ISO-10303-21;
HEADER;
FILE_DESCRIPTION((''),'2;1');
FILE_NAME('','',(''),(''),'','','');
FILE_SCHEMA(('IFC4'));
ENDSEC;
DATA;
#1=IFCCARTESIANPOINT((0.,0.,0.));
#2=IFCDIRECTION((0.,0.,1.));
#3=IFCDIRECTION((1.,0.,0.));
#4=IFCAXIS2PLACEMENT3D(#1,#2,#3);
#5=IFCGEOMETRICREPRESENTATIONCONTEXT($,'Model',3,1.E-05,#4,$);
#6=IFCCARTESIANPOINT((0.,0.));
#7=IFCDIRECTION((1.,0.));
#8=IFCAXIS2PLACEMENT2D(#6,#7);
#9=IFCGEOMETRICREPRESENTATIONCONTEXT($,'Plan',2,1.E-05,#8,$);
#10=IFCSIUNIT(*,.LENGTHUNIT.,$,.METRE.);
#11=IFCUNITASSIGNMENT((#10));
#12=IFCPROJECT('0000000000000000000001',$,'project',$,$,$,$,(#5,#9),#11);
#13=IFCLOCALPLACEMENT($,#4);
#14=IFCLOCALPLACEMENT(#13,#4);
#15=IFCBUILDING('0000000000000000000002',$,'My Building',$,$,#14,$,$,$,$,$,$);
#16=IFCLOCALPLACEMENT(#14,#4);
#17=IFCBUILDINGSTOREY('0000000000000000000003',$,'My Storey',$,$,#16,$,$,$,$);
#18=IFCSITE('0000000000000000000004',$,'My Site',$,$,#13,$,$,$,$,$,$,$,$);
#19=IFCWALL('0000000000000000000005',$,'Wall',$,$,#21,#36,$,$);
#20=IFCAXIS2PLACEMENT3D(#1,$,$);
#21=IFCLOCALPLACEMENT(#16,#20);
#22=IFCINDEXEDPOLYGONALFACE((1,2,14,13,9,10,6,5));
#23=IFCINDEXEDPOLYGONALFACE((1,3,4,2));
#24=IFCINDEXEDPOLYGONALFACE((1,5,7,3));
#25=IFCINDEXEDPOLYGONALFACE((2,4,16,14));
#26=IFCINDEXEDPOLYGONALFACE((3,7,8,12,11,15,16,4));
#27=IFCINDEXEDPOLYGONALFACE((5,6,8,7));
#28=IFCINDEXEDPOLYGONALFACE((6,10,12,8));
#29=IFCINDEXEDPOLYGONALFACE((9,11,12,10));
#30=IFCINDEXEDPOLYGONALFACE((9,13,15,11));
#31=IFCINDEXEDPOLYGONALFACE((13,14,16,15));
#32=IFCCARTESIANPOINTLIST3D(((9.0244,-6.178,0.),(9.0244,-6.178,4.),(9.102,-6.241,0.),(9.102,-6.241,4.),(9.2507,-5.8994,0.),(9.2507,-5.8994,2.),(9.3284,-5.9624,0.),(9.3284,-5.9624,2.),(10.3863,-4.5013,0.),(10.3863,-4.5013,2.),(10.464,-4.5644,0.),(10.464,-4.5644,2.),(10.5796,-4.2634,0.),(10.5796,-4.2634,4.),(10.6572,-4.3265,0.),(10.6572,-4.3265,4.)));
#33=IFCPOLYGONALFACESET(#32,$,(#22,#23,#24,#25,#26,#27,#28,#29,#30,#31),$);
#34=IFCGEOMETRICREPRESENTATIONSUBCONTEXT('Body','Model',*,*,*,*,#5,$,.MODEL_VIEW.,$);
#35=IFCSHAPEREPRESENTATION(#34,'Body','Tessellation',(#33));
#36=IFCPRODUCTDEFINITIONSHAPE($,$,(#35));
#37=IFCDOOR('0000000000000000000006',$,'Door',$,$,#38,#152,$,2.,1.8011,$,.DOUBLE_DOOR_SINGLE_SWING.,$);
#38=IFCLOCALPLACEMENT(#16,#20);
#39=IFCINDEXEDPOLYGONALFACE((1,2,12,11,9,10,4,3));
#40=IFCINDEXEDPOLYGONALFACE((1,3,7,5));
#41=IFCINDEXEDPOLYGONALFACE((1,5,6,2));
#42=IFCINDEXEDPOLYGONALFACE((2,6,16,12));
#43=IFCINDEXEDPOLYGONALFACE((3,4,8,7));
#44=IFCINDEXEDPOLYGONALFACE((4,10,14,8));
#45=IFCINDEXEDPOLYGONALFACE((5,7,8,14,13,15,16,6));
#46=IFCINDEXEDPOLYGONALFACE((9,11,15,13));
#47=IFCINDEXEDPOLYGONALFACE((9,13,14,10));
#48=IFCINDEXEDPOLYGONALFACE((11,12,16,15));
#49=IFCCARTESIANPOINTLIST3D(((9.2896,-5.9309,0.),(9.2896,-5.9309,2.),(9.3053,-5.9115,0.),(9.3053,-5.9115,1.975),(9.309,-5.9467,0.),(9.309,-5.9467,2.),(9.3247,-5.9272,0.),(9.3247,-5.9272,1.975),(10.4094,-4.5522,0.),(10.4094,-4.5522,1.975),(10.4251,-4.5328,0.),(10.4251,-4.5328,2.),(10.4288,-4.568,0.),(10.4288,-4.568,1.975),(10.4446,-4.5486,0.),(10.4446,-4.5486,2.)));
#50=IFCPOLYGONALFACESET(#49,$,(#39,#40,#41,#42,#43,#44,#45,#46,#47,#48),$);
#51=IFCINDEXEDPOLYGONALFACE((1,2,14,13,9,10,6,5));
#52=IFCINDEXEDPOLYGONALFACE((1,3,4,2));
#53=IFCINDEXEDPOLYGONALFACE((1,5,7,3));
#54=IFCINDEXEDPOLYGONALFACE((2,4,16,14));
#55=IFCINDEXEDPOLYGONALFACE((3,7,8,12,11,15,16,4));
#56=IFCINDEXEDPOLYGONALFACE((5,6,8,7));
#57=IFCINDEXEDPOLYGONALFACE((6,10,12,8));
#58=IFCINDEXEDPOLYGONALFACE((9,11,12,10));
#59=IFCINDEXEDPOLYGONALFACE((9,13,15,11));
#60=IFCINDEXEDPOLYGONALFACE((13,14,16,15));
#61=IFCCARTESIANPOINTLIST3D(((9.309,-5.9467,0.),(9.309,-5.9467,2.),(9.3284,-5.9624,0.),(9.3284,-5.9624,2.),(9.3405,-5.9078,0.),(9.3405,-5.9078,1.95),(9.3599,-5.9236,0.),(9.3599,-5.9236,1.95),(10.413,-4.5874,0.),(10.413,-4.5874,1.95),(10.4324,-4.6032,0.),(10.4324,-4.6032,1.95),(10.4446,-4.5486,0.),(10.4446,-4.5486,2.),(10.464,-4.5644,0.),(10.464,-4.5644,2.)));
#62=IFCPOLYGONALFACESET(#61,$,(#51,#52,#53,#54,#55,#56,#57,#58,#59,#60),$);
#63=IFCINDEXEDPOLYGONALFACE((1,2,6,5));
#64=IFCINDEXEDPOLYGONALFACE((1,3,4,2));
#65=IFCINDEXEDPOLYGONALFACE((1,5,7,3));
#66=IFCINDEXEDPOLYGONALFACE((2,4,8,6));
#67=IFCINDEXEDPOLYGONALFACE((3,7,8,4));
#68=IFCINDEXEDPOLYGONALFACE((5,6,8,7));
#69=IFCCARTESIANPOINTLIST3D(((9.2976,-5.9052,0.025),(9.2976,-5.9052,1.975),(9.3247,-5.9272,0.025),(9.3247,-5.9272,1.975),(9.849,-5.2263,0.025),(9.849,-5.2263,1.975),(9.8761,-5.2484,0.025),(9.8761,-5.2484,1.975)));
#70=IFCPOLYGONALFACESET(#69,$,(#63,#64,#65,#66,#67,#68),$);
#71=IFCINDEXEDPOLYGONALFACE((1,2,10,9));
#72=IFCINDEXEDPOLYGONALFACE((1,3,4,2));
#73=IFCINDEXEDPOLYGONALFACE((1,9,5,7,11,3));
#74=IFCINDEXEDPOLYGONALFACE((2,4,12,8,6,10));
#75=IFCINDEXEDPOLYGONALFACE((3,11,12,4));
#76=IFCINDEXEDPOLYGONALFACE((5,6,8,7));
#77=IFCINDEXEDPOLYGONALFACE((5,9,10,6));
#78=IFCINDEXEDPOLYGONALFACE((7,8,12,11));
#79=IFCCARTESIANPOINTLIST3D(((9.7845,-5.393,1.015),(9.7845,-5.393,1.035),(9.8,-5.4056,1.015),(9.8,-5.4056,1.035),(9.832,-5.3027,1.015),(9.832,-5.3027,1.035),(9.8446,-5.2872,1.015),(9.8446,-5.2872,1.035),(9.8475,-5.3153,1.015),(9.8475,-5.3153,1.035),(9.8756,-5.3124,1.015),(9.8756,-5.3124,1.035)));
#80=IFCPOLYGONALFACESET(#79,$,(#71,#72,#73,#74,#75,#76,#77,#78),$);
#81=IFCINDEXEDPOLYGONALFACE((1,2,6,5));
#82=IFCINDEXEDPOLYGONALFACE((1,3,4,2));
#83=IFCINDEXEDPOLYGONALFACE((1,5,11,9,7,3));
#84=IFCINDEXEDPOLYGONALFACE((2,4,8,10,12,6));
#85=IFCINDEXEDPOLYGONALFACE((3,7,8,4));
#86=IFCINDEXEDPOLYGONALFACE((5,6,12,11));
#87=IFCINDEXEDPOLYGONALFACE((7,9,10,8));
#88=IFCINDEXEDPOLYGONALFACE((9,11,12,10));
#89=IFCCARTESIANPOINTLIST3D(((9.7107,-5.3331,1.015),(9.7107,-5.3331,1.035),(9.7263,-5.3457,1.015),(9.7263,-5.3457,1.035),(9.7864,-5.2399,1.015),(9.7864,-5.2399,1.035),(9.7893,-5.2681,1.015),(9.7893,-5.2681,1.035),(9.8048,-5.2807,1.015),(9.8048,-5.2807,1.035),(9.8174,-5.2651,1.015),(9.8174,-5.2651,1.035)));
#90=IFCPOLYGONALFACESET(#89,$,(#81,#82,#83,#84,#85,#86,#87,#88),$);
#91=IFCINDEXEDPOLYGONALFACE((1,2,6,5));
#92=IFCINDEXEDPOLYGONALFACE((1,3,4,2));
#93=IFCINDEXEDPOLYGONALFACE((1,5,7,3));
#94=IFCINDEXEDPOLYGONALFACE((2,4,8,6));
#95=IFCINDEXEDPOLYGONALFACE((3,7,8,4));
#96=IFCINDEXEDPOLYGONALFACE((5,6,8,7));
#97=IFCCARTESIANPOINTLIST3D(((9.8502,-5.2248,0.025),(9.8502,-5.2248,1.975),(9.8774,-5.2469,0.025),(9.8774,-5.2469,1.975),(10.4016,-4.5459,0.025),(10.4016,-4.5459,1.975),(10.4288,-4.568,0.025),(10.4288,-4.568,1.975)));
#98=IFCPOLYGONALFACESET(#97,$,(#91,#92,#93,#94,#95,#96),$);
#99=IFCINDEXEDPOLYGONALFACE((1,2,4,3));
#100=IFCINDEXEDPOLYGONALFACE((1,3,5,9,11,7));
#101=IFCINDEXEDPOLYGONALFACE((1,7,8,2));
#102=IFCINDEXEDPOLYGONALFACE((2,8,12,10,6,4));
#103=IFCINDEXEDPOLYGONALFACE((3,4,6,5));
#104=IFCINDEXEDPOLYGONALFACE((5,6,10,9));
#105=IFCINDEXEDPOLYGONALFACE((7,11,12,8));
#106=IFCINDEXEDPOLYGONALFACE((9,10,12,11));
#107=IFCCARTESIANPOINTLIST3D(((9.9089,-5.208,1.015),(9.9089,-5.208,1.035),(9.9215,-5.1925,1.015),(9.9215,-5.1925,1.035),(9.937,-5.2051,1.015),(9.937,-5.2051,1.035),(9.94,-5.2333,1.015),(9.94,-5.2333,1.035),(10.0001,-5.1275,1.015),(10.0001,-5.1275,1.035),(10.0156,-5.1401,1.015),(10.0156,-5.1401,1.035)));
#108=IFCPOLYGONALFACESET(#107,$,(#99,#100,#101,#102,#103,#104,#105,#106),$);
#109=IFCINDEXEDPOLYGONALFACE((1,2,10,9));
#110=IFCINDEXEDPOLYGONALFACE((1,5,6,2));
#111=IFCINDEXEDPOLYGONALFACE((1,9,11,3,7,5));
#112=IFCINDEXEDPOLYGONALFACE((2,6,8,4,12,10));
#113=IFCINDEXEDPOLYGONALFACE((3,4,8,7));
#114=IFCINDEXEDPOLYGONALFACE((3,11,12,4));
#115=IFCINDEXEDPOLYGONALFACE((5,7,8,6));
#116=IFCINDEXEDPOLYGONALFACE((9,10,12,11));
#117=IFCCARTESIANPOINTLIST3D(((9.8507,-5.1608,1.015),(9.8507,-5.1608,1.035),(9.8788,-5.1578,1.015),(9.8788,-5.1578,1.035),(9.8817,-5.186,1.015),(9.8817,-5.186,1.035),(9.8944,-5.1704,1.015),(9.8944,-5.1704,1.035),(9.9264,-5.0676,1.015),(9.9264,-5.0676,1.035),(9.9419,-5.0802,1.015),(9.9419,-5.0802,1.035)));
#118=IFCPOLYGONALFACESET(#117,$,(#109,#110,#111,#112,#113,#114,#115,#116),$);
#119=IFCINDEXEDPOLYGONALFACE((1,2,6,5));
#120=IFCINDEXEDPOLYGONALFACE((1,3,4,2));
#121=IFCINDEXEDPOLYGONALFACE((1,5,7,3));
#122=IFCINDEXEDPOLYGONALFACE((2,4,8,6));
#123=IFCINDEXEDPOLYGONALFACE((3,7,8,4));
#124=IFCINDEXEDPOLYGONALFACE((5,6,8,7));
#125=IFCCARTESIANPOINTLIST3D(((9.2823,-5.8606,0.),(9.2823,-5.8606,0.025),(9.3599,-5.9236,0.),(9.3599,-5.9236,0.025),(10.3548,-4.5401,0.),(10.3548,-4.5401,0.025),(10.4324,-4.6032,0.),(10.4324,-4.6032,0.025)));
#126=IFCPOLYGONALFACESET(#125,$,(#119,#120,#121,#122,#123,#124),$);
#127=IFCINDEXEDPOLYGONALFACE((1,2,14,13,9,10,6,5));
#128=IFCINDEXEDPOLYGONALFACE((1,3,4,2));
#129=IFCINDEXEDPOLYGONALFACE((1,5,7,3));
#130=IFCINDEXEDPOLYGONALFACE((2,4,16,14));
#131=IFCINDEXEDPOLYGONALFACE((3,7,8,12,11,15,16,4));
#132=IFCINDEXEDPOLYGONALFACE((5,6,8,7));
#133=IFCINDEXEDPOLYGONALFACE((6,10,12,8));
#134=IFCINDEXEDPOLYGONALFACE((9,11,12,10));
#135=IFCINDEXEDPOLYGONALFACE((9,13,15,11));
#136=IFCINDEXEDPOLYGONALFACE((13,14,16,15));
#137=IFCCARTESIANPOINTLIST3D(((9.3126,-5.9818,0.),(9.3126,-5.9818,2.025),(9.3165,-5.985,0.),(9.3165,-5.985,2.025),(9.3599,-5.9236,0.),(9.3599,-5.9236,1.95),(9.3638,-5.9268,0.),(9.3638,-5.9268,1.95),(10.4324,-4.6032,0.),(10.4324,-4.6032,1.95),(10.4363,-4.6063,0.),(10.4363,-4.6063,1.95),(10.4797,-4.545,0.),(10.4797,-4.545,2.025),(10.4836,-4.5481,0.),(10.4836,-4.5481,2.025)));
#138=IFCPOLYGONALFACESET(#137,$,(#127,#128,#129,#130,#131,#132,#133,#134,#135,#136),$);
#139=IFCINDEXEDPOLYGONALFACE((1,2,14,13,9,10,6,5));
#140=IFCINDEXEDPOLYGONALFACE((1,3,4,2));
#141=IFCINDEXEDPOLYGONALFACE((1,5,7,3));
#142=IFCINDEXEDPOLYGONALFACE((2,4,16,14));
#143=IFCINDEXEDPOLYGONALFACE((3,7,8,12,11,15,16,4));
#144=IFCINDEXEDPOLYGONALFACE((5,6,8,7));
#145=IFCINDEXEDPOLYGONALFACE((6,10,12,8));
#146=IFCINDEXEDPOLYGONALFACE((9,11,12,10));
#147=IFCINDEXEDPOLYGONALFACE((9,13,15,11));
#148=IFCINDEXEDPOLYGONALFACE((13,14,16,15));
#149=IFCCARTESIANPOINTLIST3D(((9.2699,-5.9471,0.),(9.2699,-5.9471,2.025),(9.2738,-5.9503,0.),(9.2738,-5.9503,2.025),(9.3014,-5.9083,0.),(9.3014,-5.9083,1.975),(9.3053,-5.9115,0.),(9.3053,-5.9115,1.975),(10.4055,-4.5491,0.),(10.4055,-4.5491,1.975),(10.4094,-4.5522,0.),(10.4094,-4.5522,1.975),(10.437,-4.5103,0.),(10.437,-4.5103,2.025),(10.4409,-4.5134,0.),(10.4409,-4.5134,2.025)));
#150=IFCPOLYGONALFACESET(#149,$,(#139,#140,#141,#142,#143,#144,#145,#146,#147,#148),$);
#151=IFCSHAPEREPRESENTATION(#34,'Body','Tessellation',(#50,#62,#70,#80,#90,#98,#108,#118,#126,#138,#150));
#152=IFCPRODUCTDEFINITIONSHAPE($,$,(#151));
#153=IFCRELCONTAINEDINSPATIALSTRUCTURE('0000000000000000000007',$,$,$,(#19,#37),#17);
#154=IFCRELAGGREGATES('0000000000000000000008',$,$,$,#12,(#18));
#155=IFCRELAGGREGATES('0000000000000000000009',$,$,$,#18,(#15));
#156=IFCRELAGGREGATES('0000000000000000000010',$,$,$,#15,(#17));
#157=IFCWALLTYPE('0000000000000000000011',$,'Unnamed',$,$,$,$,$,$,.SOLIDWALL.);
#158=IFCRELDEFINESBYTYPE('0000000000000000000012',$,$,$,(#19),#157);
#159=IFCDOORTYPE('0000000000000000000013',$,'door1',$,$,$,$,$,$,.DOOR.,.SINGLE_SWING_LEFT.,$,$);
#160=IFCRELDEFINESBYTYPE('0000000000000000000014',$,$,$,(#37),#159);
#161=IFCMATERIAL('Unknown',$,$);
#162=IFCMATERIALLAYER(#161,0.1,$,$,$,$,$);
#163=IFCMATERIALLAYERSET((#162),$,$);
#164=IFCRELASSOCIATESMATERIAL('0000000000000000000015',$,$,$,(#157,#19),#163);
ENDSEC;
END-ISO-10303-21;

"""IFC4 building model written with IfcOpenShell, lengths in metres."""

from ifc_helpers import new_model, entity, si_unit, frame, origin_with_axes, origin_2d_with_axis, place, context, subcontext, project, spatial, line, indexed_curve, outline, extrude, shape, source, transform, mapped, material, layer, layer_set, layer_usage, type_object, type_shapes, element, fill, save


model = new_model("IFC4")

# Units and contexts
model_context = context("Model", 3, precision=1e-05, world=origin_with_axes())
plan_context = context("Plan", 2, precision=1e-05, world=origin_2d_with_axis())
body_context_1 = subcontext(model_context, "Body", "Model", "MODEL_VIEW")
body_context_2 = subcontext(plan_context, "Body", "Plan", "PLAN_VIEW")
ifc_project = project(units=[si_unit("LENGTHUNIT", "METRE")], contexts=[model_context, plan_context])

# Site, building, storey
site_placement = place(None, origin_with_axes())
site = spatial("IfcSite", under=ifc_project, at=site_placement, Name="My Site")
building_placement = place(site_placement, origin_with_axes())
building = spatial("IfcBuilding", under=site, at=building_placement, Name="My Building")
storey_placement = place(building_placement, origin_with_axes())
storey = spatial("IfcBuildingStorey", under=building, at=storey_placement, Name="My Storey")

# Shared definitions
ifc_material = material(Name="Unknown")

# Shared definitions
ifc_layer_1 = layer(ifc_material, 0.1)
ifc_layer_set_1 = layer_set([ifc_layer_1])
wall_type = type_object("IfcWallType", Name="Unnamed", PredefinedType="SOLIDWALL", material=ifc_layer_set_1)

# Wall, opening, door
ifc_layer_usage_1 = layer_usage(ifc_layer_set_1, "AXIS2", "POSITIVE", 0.0)
wall_1_placement = place(storey_placement, frame((10.5796, -4.2634, 0.0), z_axis=(0.0, 0.0, 1.0), x_axis=(-0.630485, -0.776202, 0.0)))
wall_1 = element("IfcWall", 1, at=wall_1_placement, inside=storey, type_object=wall_type, material=ifc_layer_usage_1, Name="Wall", context=body_context_1, shape_type="SweptSolid", body=[
    extrude(outline(indexed_curve([(0.0, 0.0), (0.0, 0.1), (2.4666, 0.1), (2.4666, 0.0)], segments=[line(1, 2, 3, 4, 1)])), origin_with_axes(), (0.0, 0.0, 1.0), 4.0),
])
shared_shape_1 = source(origin_with_axes(), body_context_1, "Body", "SweptSolid", [
    extrude(outline(indexed_curve([(0.0, 0.0), (1.8011, 0.0), (1.8011, 2.0), (0.0, 2.0)], segments=[line(1, 2, 3, 4, 1)])), frame((0.0, -0.6, 0.0), z_axis=(0.0, -1.0, 0.0), x_axis=(1.0, 0.0, 0.0)), (0.0, 0.0, -1.0), 1.2),
])
opening_placement = place(wall_1_placement, frame((2.1076, 0.1, 0.0), z_axis=(0.0, 0.0, 1.0), x_axis=(-1.0, 0.0, 0.0)))
opening = element("IfcOpeningElement", 2, at=opening_placement, cuts=wall_1, PredefinedType="OPENING", context=body_context_1, shape_type="MappedRepresentation", body=[
    mapped(shared_shape_1, transform((0.0, 0.0, 0.0), x_axis=(1.0, 0.0, 0.0), y_axis=(0.0, 1.0, 0.0), z_axis=(0.0, 0.0, 1.0), scale=1.0)),
])
door_type = type_object("IfcDoorType", Name="door1", OperationType="SINGLE_SWING_LEFT", PredefinedType="DOOR")
shared_shape_2 = source(origin_with_axes(), body_context_1, "Body", "SweptSolid", [
    extrude(outline(indexed_curve([(0.0, 0.0), (0.0, 2.0), (1.8011, 2.0), (1.8011, 0.0), (1.7761, 0.0), (1.7761, 1.975), (0.025, 1.975), (0.025, 0.0)], segments=[line(1, 2, 3, 4, 5, 6, 7, 8, 1)])), frame((0.0, 0.025, 0.0), z_axis=(0.0, -1.0, 0.0), x_axis=(1.0, 0.0, 0.0)), (0.0, 0.0, -1.0), 0.025),
    extrude(outline(indexed_curve([(0.0, 0.0), (0.0, 2.0), (1.8011, 2.0), (1.8011, 0.0), (1.7511, 0.0), (1.7511, 1.95), (0.05, 1.95), (0.05, 0.0)], segments=[line(1, 2, 3, 4, 5, 6, 7, 8, 1)])), frame((0.0, 0.0, 0.0), z_axis=(0.0, -1.0, 0.0), x_axis=(1.0, 0.0, 0.0)), (0.0, 0.0, -1.0), 0.025),
    extrude(outline(indexed_curve([(0.0, 0.0), (0.8746, 0.0), (0.8746, 0.035), (0.0, 0.035)], segments=[line(1, 2, 3, 4, 1)])), frame((0.025, 0.025, 0.025), z_axis=(0.0, 0.0, 1.0), x_axis=(1.0, 0.0, 0.0)), (0.0, 0.0, 1.0), 1.95),
    extrude(outline(indexed_curve([(0.0, 0.0), (0.0, -0.04), (-0.12, -0.04), (-0.12, -0.02), (-0.02, -0.02), (-0.02, 0.0)], segments=[line(1, 2, 3, 4, 5, 6, 1)])), frame((0.8496, 0.025, 1.015), z_axis=(0.0, 0.0, 1.0), x_axis=(1.0, 0.0, 0.0)), (0.0, 0.0, 1.0), 0.02),
    extrude(outline(indexed_curve([(0.0, 0.0), (0.0, 0.04), (-0.12, 0.04), (-0.12, 0.02), (-0.02, 0.02), (-0.02, 0.0)], segments=[line(1, 2, 3, 4, 5, 6, 1)])), frame((0.8496, 0.06, 1.015), z_axis=(0.0, 0.0, 1.0), x_axis=(1.0, 0.0, 0.0)), (0.0, 0.0, 1.0), 0.02),
    extrude(outline(indexed_curve([(0.0, 0.0), (-0.8746, 0.0), (-0.8746, 0.035), (0.0, 0.035)], segments=[line(1, 2, 3, 4, 1)])), frame((1.7761, 0.025, 0.025), z_axis=(0.0, 0.0, 1.0), x_axis=(1.0, 0.0, 0.0)), (0.0, 0.0, 1.0), 1.95),
    extrude(outline(indexed_curve([(0.0, 0.0), (0.0, -0.04), (0.12, -0.04), (0.12, -0.02), (0.02, -0.02), (0.02, 0.0)], segments=[line(1, 2, 3, 4, 5, 6, 1)])), frame((0.9516, 0.025, 1.015), z_axis=(0.0, 0.0, 1.0), x_axis=(1.0, 0.0, 0.0)), (0.0, 0.0, 1.0), 0.02),
    extrude(outline(indexed_curve([(0.0, 0.0), (0.0, 0.04), (0.12, 0.04), (0.12, 0.02), (0.02, 0.02), (0.02, 0.0)], segments=[line(1, 2, 3, 4, 5, 6, 1)])), frame((0.9516, 0.06, 1.015), z_axis=(0.0, 0.0, 1.0), x_axis=(1.0, 0.0, 0.0)), (0.0, 0.0, 1.0), 0.02),
    extrude(outline(indexed_curve([(0.0, 0.0), (1.7011, 0.0), (1.7011, 0.1), (0.0, 0.1)], segments=[line(1, 2, 3, 4, 1)])), frame((0.05, 0.0, 0.0), z_axis=(0.0, 0.0, 1.0), x_axis=(1.0, 0.0, 0.0)), (0.0, 0.0, 1.0), 0.025),
    extrude(outline(indexed_curve([(0.0, 0.0), (0.0, 2.025), (1.8511, 2.025), (1.8511, 0.0), (1.7761, 0.0), (1.7761, 1.95), (0.075, 1.95), (0.075, 0.0)], segments=[line(1, 2, 3, 4, 5, 6, 7, 8, 1)])), frame((-0.025, -0.005, 0.0), z_axis=(0.0, -1.0, 0.0), x_axis=(1.0, 0.0, 0.0)), (0.0, 0.0, -1.0), 0.005),
    extrude(outline(indexed_curve([(0.0, 0.0), (0.0, 2.025), (1.8511, 2.025), (1.8511, 0.0), (1.8011, 0.0), (1.8011, 1.975), (0.05, 1.975), (0.05, 0.0)], segments=[line(1, 2, 3, 4, 5, 6, 7, 8, 1)])), frame((-0.025, 0.05, 0.0), z_axis=(0.0, -1.0, 0.0), x_axis=(1.0, 0.0, 0.0)), (0.0, 0.0, -1.0), 0.005),
])
shared_shape_3 = source(origin_with_axes(), body_context_2, "Body", "Curve2D", [
    entity("IfcIndexedPolyCurve", entity("IfcCartesianPointList2D", [[0.0, 0.0], [0.0, 0.05], [0.025, 0.05], [0.025, 0.025], [0.05, 0.025], [0.05, 0.0]]), [entity("IfcLineIndex", [1, 2, 3, 4, 5, 6, 1])]),
    entity("IfcIndexedPolyCurve", entity("IfcCartesianPointList2D", [[1.8011, 0.0], [1.8011, 0.05], [1.7761, 0.05], [1.7761, 0.025], [1.7511, 0.025], [1.7511, 0.0]]), [entity("IfcLineIndex", [1, 2, 3, 4, 5, 6, 1])]),
    entity("IfcTrimmedCurve", entity("IfcEllipse", entity("IfcAxis2Placement2D", entity("IfcCartesianPoint", [0.06, 0.05]), entity("IfcDirection", [1.0, 0.0])), 0.8406, 0.8756), [entity("IfcCartesianPoint", [0.9006, 0.05])], [entity("IfcCartesianPoint", [0.06, 0.9256])], True, "CARTESIAN"),
    entity("IfcIndexedPolyCurve", entity("IfcCartesianPointList2D", [[0.025, 0.05], [0.06, 0.05], [0.06, 0.9256], [0.025, 0.9256]]), [entity("IfcLineIndex", [1, 2, 3, 4, 1])]),
    entity("IfcTrimmedCurve", entity("IfcEllipse", entity("IfcAxis2Placement2D", entity("IfcCartesianPoint", [1.7411, 0.05]), entity("IfcDirection", [1.0, 0.0])), 0.8406, 0.8756), [entity("IfcCartesianPoint", [1.7411, 0.9256])], [entity("IfcCartesianPoint", [0.9006, 0.05])], True, "CARTESIAN"),
    entity("IfcIndexedPolyCurve", entity("IfcCartesianPointList2D", [[1.7761, 0.05], [1.7411, 0.05], [1.7411, 0.9256], [1.7761, 0.9256]]), [entity("IfcLineIndex", [1, 2, 3, 4, 1])]),
])
type_shapes(door_type, [shared_shape_2, shared_shape_3])
door_placement = place(opening_placement, frame((0.0, 0.0, 0.0), z_axis=(0.0, 0.0, 1.0), x_axis=(1.0, 0.0, 0.0)))
door = element("IfcDoor", 3, at=door_placement, inside=storey, type_object=door_type, Name="Door", OperationType="DOUBLE_DOOR_SINGLE_SWING", OverallHeight=2.0, OverallWidth=1.8011, shapes=[
    shape(body_context_1, "Body", "MappedRepresentation", [mapped(shared_shape_2, transform((0.0, 0.0, 0.0), x_axis=(1.0, 0.0, 0.0), y_axis=(0.0, 1.0, 0.0), z_axis=(0.0, 0.0, 1.0), scale=1.0))]),
    shape(body_context_2, "Body", "MappedRepresentation", [mapped(shared_shape_3, transform((0.0, 0.0, 0.0), x_axis=(1.0, 0.0, 0.0), y_axis=(0.0, 1.0, 0.0), z_axis=(0.0, 0.0, 1.0), scale=1.0))]),
])
fill(opening, door)

save(model, "model.ifc")
